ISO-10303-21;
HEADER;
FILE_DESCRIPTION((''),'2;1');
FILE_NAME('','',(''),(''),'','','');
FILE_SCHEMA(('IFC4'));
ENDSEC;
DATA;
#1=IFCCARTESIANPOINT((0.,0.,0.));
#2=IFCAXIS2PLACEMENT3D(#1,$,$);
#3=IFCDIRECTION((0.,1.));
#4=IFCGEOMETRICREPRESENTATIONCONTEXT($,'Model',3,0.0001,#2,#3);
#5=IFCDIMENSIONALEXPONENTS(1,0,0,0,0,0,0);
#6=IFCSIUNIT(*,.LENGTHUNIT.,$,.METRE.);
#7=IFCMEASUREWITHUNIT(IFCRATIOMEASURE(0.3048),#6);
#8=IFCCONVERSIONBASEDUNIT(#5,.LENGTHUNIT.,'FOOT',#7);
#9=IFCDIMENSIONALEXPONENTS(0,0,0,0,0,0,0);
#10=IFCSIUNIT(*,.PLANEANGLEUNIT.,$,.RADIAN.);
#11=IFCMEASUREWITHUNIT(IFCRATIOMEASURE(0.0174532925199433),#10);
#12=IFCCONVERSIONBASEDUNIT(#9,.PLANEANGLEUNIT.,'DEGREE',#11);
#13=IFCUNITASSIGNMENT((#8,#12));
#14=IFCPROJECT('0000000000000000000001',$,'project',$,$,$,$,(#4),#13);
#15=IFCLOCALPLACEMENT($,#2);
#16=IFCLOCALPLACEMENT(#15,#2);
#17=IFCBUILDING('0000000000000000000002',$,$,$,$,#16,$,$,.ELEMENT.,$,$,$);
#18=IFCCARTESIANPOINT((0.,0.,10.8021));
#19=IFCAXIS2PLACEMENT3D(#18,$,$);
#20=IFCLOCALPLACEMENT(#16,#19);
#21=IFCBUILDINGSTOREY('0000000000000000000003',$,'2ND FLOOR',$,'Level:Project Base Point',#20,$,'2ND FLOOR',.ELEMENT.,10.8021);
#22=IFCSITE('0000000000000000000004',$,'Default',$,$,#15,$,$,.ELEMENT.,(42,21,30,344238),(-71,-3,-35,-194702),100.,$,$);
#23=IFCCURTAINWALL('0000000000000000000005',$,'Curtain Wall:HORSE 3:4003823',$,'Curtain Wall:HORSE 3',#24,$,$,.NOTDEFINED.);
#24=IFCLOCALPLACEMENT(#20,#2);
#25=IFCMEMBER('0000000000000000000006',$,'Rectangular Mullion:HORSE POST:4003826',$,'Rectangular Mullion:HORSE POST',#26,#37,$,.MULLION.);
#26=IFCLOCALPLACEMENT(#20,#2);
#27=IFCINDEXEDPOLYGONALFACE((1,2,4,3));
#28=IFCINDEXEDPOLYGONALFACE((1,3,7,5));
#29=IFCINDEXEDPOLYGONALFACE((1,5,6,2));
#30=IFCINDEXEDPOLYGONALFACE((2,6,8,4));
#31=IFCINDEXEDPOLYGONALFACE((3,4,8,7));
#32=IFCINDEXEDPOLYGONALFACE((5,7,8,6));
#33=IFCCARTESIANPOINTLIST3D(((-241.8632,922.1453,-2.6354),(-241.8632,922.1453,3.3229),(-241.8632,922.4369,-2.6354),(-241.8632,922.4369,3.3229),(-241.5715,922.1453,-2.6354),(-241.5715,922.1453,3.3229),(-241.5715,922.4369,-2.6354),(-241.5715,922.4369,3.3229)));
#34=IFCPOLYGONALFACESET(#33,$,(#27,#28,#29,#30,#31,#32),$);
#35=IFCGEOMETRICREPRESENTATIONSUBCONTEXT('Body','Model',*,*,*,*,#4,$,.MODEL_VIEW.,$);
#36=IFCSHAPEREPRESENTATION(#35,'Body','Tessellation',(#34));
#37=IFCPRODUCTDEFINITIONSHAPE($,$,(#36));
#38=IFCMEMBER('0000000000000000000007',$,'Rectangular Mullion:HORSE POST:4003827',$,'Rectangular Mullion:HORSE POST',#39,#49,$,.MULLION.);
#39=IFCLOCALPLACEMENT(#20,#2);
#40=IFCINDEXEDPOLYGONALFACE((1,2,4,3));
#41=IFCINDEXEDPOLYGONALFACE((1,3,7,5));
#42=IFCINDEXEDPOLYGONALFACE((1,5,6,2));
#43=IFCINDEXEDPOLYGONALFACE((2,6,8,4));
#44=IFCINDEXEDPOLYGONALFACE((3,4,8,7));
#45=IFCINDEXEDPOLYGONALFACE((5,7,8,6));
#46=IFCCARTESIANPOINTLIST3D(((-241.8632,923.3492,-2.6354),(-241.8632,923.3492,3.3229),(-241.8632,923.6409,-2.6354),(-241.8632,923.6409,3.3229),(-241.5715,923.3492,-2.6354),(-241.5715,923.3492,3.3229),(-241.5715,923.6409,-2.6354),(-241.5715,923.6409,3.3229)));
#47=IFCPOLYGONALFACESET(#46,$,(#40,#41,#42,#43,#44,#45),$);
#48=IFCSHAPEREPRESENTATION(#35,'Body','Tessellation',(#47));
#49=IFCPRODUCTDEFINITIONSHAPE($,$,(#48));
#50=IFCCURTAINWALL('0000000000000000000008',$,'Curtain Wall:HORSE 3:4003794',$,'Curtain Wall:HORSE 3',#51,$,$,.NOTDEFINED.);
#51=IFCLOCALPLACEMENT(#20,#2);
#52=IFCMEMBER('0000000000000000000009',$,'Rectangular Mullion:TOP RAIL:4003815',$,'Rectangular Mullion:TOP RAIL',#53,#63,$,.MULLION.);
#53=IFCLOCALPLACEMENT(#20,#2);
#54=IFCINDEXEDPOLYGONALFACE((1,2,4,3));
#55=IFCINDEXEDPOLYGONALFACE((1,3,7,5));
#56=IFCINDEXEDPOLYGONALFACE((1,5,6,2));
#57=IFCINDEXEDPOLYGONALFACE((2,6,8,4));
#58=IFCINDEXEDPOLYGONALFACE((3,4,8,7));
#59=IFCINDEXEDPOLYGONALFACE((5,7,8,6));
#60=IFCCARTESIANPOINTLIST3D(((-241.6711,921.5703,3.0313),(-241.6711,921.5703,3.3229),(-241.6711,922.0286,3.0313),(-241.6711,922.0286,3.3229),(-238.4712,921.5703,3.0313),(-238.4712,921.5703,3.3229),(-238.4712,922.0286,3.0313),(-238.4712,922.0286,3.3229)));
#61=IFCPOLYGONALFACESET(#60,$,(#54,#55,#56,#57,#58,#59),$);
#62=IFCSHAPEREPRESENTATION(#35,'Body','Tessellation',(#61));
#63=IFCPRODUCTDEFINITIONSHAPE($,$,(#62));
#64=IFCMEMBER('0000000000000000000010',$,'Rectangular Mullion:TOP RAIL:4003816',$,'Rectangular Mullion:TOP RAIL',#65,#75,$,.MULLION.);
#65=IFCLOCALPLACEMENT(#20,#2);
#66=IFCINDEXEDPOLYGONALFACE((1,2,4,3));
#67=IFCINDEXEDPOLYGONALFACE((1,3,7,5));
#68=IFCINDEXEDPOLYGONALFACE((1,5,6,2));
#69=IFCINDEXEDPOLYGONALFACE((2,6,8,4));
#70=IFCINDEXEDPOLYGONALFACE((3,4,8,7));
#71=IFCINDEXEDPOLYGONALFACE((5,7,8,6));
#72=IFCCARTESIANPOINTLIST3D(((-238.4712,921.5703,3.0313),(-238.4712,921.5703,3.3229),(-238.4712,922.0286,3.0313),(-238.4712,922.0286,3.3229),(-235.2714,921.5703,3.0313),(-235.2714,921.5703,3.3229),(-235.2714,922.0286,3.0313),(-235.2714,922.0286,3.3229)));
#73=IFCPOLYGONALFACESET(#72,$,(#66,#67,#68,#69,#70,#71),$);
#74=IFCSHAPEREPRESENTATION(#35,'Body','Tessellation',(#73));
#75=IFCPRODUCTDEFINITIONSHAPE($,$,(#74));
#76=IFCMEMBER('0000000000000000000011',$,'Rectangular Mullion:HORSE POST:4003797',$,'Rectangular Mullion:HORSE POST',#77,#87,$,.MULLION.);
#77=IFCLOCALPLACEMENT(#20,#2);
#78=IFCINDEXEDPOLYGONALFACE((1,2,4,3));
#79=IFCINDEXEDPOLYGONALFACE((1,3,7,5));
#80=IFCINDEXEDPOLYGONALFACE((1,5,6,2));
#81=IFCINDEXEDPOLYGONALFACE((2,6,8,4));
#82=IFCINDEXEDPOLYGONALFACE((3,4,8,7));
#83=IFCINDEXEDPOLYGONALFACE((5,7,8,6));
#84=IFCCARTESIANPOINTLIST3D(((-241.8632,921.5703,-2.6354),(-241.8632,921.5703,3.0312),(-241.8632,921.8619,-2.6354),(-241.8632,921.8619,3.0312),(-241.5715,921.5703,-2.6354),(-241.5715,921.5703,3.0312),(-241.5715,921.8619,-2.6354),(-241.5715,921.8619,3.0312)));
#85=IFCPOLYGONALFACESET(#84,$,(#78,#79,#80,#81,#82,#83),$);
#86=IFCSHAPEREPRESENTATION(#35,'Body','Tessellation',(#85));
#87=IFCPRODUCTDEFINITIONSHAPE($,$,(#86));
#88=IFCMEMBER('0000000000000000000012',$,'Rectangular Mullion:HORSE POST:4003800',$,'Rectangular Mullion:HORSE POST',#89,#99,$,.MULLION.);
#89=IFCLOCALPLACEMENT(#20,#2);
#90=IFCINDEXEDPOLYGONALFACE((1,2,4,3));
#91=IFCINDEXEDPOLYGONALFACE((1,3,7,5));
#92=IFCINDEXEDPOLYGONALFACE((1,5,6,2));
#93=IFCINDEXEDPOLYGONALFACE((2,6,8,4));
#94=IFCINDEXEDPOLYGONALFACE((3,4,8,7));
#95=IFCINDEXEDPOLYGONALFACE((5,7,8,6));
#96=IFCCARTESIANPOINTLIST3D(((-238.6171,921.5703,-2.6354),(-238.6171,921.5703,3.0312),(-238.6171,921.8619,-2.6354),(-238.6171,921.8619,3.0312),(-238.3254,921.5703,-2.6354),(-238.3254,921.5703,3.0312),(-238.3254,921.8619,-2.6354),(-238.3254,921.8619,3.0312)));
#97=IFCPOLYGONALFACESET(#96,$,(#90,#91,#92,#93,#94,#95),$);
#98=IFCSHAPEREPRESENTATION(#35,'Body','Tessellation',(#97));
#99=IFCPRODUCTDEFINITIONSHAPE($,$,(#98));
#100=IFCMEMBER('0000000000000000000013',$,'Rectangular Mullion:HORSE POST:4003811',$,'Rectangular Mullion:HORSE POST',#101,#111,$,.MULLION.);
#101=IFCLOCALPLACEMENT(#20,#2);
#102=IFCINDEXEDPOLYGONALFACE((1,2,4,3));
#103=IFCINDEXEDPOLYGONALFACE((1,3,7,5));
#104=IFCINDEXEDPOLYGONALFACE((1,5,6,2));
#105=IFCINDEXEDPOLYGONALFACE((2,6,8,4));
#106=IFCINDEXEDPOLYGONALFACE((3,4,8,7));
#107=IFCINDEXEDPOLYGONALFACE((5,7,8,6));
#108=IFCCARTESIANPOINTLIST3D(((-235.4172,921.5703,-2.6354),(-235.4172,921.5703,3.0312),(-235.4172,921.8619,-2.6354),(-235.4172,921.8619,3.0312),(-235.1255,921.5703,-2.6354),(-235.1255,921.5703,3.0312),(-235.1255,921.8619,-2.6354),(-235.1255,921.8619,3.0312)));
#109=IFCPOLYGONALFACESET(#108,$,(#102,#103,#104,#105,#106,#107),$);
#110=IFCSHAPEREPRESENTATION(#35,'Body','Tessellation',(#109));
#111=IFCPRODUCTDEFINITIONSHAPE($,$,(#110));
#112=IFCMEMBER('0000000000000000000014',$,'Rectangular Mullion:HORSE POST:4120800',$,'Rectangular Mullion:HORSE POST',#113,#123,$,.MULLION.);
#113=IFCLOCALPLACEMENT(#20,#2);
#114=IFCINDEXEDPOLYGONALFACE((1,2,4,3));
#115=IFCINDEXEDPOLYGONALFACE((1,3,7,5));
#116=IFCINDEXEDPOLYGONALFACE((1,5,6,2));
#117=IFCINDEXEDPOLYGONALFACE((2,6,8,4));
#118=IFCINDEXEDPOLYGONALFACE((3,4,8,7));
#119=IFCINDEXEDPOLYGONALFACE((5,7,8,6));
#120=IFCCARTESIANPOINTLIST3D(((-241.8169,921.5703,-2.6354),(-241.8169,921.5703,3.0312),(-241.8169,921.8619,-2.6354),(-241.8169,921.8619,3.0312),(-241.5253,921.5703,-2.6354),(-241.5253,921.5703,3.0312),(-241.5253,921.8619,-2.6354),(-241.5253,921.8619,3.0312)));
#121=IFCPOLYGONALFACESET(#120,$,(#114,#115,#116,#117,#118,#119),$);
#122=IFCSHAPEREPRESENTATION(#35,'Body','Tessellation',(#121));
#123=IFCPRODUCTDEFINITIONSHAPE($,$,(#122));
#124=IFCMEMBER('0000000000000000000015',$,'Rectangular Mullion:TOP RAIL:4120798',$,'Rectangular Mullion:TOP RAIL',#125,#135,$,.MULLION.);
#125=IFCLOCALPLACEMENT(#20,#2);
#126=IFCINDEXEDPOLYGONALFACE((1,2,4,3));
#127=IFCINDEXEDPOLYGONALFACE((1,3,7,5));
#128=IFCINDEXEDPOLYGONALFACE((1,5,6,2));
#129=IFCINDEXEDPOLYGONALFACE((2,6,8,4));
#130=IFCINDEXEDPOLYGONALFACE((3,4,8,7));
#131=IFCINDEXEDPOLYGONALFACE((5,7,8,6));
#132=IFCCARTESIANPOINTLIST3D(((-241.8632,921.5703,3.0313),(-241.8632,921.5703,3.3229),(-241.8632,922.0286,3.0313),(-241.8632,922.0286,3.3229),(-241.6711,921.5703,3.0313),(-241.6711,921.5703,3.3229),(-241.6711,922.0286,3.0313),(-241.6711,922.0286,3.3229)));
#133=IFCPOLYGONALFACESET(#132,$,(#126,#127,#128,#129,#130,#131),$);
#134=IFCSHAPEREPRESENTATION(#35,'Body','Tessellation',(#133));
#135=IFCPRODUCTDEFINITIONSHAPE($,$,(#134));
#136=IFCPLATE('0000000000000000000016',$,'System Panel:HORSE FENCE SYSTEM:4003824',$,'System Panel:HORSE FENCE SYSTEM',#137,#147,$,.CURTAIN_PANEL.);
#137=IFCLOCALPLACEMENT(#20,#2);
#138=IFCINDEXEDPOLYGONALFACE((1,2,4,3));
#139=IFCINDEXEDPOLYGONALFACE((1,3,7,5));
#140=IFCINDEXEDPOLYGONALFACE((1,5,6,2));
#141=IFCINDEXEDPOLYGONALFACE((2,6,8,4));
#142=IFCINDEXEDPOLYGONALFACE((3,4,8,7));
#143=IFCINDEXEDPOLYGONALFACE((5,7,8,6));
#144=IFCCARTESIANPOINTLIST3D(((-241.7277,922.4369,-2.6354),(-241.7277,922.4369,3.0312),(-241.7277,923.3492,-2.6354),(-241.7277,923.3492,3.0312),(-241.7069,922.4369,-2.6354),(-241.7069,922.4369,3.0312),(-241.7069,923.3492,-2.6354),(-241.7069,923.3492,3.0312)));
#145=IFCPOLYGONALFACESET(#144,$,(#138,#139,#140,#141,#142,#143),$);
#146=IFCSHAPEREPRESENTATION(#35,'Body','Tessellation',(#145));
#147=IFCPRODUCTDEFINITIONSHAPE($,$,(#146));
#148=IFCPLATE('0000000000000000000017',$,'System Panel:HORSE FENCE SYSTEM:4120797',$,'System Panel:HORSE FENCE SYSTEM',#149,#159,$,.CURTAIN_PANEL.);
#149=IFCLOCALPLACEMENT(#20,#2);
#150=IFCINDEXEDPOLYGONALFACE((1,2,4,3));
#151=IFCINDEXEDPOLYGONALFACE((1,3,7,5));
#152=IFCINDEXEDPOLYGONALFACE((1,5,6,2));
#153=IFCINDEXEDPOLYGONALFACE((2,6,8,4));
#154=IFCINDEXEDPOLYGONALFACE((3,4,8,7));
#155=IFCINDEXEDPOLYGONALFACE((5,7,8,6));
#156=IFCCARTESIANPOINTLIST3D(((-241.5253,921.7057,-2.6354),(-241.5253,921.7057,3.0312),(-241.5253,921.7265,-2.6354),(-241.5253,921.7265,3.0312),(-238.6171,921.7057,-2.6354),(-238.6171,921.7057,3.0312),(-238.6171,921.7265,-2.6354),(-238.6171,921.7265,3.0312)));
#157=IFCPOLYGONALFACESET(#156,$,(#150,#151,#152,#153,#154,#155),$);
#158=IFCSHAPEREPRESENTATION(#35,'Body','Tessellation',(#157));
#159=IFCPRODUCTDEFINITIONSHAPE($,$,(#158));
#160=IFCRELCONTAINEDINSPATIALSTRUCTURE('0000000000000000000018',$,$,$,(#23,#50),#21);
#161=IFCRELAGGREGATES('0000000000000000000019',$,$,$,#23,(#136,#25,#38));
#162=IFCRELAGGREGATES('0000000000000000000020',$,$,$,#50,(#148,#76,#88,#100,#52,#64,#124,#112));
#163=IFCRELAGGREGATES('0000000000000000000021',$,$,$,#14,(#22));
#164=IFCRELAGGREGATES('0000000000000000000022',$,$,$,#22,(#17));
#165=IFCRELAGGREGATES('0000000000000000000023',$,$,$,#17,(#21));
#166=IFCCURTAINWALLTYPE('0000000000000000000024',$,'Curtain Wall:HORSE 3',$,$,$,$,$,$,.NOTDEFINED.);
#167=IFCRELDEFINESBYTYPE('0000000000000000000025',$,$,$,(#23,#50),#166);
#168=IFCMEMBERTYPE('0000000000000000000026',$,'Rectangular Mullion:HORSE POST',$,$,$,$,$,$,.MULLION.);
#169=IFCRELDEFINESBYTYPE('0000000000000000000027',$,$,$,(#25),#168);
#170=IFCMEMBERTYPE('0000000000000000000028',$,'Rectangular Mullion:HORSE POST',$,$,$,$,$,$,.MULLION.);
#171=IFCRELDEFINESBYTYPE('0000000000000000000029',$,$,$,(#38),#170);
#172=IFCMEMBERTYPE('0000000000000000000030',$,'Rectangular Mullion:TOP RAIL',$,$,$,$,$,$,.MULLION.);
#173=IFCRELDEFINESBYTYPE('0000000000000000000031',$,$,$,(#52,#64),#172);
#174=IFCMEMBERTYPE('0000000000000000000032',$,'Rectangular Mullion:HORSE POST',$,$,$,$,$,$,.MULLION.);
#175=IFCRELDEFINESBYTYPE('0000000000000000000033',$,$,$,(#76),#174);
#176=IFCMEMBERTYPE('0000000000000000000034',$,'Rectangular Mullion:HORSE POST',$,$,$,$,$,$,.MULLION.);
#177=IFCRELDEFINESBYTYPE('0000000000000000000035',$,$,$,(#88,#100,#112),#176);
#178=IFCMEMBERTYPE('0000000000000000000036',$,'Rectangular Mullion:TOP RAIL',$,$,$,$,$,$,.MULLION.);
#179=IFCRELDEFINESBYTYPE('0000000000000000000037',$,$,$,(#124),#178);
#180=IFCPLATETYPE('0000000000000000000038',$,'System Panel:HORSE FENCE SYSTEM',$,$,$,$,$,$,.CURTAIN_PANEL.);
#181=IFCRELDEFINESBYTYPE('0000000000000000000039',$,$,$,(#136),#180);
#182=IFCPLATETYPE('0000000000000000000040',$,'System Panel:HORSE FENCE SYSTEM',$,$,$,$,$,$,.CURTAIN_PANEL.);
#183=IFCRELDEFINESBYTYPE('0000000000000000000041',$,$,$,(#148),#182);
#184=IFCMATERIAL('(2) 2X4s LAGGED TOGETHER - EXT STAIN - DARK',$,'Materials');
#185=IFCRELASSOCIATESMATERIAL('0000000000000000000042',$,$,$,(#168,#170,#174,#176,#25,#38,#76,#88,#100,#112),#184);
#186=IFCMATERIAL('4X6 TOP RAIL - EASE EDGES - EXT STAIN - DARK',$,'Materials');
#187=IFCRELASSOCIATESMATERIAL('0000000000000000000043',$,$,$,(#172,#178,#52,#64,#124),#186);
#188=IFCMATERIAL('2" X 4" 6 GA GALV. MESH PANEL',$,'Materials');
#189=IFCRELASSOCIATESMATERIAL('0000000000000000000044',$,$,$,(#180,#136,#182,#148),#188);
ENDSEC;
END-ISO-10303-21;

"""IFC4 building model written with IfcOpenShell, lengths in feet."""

from ifc_helpers import new_model, entity, si_unit, converted_unit, direction, frame, frame_2d, origin, origin_2d_with_axis, place, context, subcontext, project, spatial, rectangle, extrude, source, transform, mapped, material, material_profile, profile_set, profile_usage, type_object, type_shapes, element, aggregate, save


model = new_model("IFC4")

# Units and contexts
model_context = context("Model", 3, precision=0.0001, world=origin(), true_north=direction((0.0, 1.0)))
body_context = subcontext(model_context, "Body", "Model", "MODEL_VIEW")
ifc_project = project(units=[converted_unit("LENGTHUNIT", "FOOT", entity("IfcRatioMeasure", 0.3048), si_unit("LENGTHUNIT", "METRE"), dimensions=[1, 0, 0, 0, 0, 0, 0]), converted_unit("PLANEANGLEUNIT", "DEGREE", entity("IfcRatioMeasure", 0.0174532925199433), si_unit("PLANEANGLEUNIT", "RADIAN"), dimensions=[0, 0, 0, 0, 0, 0, 0])], contexts=[model_context])

# Site, building, storey
site_placement = place(None, origin())
site = spatial("IfcSite", under=ifc_project, at=site_placement, Name="Default", CompositionType="ELEMENT", RefLatitude=(42, 21, 30, 344238), RefLongitude=(-71, -3, -35, -194702), RefElevation=100.0)
building_placement = place(site_placement, origin())
building = spatial("IfcBuilding", under=site, at=building_placement, CompositionType="ELEMENT")
storey_placement = place(building_placement, frame((0.0, 0.0, 10.8021)))
storey = spatial("IfcBuildingStorey", under=building, at=storey_placement, Name="2ND FLOOR", ObjectType="Level:Project Base Point", LongName="2ND FLOOR", CompositionType="ELEMENT", Elevation=10.8021)

# Curtain walls, members
curtain_wall_type = type_object("IfcCurtainWallType", Name="Curtain Wall:HORSE 3", PredefinedType="NOTDEFINED")
curtain_wall_1_placement = place(storey_placement, frame((0.0, 0.0, -10.8021)))
curtain_wall_1 = element("IfcCurtainWall", 1, at=curtain_wall_1_placement, inside=storey, type_object=curtain_wall_type, Name="Curtain Wall:HORSE 3:4003823", ObjectType="Curtain Wall:HORSE 3", PredefinedType="NOTDEFINED")
ifc_material_1 = material(Name="4X6 TOP RAIL - EASE EDGES - EXT STAIN - DARK", Category="Materials")
ifc_material_profile_1 = material_profile(ifc_material_1, rectangle(XDim=0.4583, YDim=0.2917, at=origin_2d_with_axis()), Name="TOP RAIL")
ifc_profile_set_1 = profile_set([ifc_material_profile_1], Name="TOP RAIL")
placement = place(building_placement, frame((0.0, 0.0, 21.4688)))
ifc_material_2 = material(Name="(2) 2X4s LAGGED TOGETHER - EXT STAIN - DARK", Category="Materials")
ifc_material_profile_2 = material_profile(ifc_material_2, rectangle(XDim=0.2917, YDim=0.2917, at=frame_2d((0.0, 0.0), x_axis=(1.0, 0.0))), Name="HORSE POST")
ifc_profile_set_2 = profile_set([ifc_material_profile_2], Name="HORSE POST")
ifc_profile_usage_1 = profile_usage(ifc_profile_set_2)
member_type_1 = type_object("IfcMemberType", Name="Rectangular Mullion:HORSE POST", PredefinedType="MULLION", material=ifc_profile_set_2)
shared_shape_1 = source(origin(), body_context, "Body", "SweptSolid", [
    extrude(rectangle(XDim=0.2917, YDim=0.2917, at=origin_2d_with_axis()), frame((-0.1458, 0.1458, -5.9583), z_axis=(0.0, 0.0, 1.0), x_axis=(0.0, -1.0, 0.0)), (0.0, 0.0, 1.0), 5.9583),
])
type_shapes(member_type_1, [shared_shape_1])
member_1_placement = place(placement, frame((-241.5715, 922.1453, -13.3021), z_axis=(0.0, 0.0, -1.0), x_axis=(0.0, -1.0, 0.0)))
member_1 = element("IfcMember", 2, at=member_1_placement, type_object=member_type_1, material=ifc_profile_usage_1, Name="Rectangular Mullion:HORSE POST:4003826", ObjectType="Rectangular Mullion:HORSE POST", PredefinedType="MULLION", context=body_context, shape_type="MappedRepresentation", body=[
    mapped(shared_shape_1, transform((0.0, 0.0, 0.0), scale=1.0)),
])
ifc_profile_usage_2 = profile_usage(ifc_profile_set_2)
member_type_2 = type_object("IfcMemberType", Name="Rectangular Mullion:HORSE POST", PredefinedType="MULLION", material=ifc_profile_set_2)
shared_shape_2 = source(origin(), body_context, "Body", "SweptSolid", [
    extrude(rectangle(XDim=0.2917, YDim=0.2917, at=origin_2d_with_axis()), frame((-0.1458, 0.1458, -5.9583), z_axis=(0.0, 0.0, 1.0), x_axis=(0.0, -1.0, 0.0)), (0.0, 0.0, 1.0), 5.9583),
])
type_shapes(member_type_2, [shared_shape_2])
member_2_placement = place(placement, frame((-241.5715, 923.6409, -7.3438), z_axis=(0.0, 0.0, 1.0), x_axis=(0.0, 1.0, 0.0)))
member_2 = element("IfcMember", 3, at=member_2_placement, type_object=member_type_2, material=ifc_profile_usage_2, Name="Rectangular Mullion:HORSE POST:4003827", ObjectType="Rectangular Mullion:HORSE POST", PredefinedType="MULLION", context=body_context, shape_type="MappedRepresentation", body=[
    mapped(shared_shape_2, transform((0.0, 0.0, 0.0), scale=1.0)),
])
curtain_wall_2_placement = place(storey_placement, frame((0.0, 0.0, -10.8021)))
curtain_wall_2 = element("IfcCurtainWall", 4, at=curtain_wall_2_placement, inside=storey, type_object=curtain_wall_type, Name="Curtain Wall:HORSE 3:4003794", ObjectType="Curtain Wall:HORSE 3", PredefinedType="NOTDEFINED")
ifc_profile_usage_3 = profile_usage(ifc_profile_set_1)
member_type_3 = type_object("IfcMemberType", Name="Rectangular Mullion:TOP RAIL", PredefinedType="MULLION", material=ifc_profile_set_1)
shared_shape_3 = source(origin(), body_context, "Body", "SweptSolid", [
    extrude(rectangle(XDim=0.4583, YDim=0.2917, at=origin_2d_with_axis()), frame((-0.1458, 0.0625, -3.1999), z_axis=(0.0, 0.0, 1.0), x_axis=(0.0, -1.0, 0.0)), (0.0, 0.0, 1.0), 3.1999),
])
type_shapes(member_type_3, [shared_shape_3])
member_3_placement = place(storey_placement, frame((-238.4712, 921.8619, 3.3229), z_axis=(1.0, 0.0, 0.0), x_axis=(0.0, 0.0, 1.0)))
member_3 = element("IfcMember", 5, at=member_3_placement, type_object=member_type_3, material=ifc_profile_usage_3, Name="Rectangular Mullion:TOP RAIL:4003815", ObjectType="Rectangular Mullion:TOP RAIL", PredefinedType="MULLION", context=body_context, shape_type="MappedRepresentation", body=[
    mapped(shared_shape_3, transform((0.0, 0.0, 0.0), scale=1.0)),
])
ifc_profile_usage_4 = profile_usage(ifc_profile_set_1)
member_4_placement = place(storey_placement, frame((-235.2714, 921.8619, 3.3229), z_axis=(1.0, 0.0, 0.0), x_axis=(0.0, 0.0, 1.0)))
member_4 = element("IfcMember", 6, at=member_4_placement, type_object=member_type_3, material=ifc_profile_usage_4, Name="Rectangular Mullion:TOP RAIL:4003816", ObjectType="Rectangular Mullion:TOP RAIL", PredefinedType="MULLION", context=body_context, shape_type="MappedRepresentation", body=[
    mapped(shared_shape_3, transform((0.0, 0.0, 0.0), scale=1.0)),
])
ifc_profile_usage_5 = profile_usage(ifc_profile_set_2)
member_type_4 = type_object("IfcMemberType", Name="Rectangular Mullion:HORSE POST", PredefinedType="MULLION", material=ifc_profile_set_2)
shared_shape_4 = source(origin(), body_context, "Body", "SweptSolid", [
    extrude(rectangle(XDim=0.2917, YDim=0.2917, at=origin_2d_with_axis()), frame((-0.1458, 0.1458, -5.6667), z_axis=(0.0, 0.0, 1.0), x_axis=(0.0, -1.0, 0.0)), (0.0, 0.0, 1.0), 5.6667),
])
type_shapes(member_type_4, [shared_shape_4])
member_5_placement = place(placement, frame((-241.8632, 921.8619, -7.6354), z_axis=(0.0, 0.0, 1.0), x_axis=(-1.0, 0.0, 0.0)))
member_5 = element("IfcMember", 7, at=member_5_placement, type_object=member_type_4, material=ifc_profile_usage_5, Name="Rectangular Mullion:HORSE POST:4003797", ObjectType="Rectangular Mullion:HORSE POST", PredefinedType="MULLION", context=body_context, shape_type="MappedRepresentation", body=[
    mapped(shared_shape_4, transform((0.0, 0.0, 0.0), scale=1.0)),
])
ifc_profile_usage_6 = profile_usage(ifc_profile_set_2)
member_type_5 = type_object("IfcMemberType", Name="Rectangular Mullion:HORSE POST", PredefinedType="MULLION", material=ifc_profile_set_2)
shared_shape_5 = source(origin(), body_context, "Body", "SweptSolid", [
    extrude(rectangle(XDim=0.2917, YDim=0.2917, at=origin_2d_with_axis()), frame((0.0, 0.1458, -5.6667), z_axis=(0.0, 0.0, 1.0), x_axis=(0.0, -1.0, 0.0)), (0.0, 0.0, 1.0), 5.6667),
])
type_shapes(member_type_5, [shared_shape_5])
member_6_placement = place(placement, frame((-238.4712, 921.8619, -13.3021), z_axis=(0.0, 0.0, -1.0), x_axis=(1.0, 0.0, 0.0)))
member_6 = element("IfcMember", 8, at=member_6_placement, type_object=member_type_5, material=ifc_profile_usage_6, Name="Rectangular Mullion:HORSE POST:4003800", ObjectType="Rectangular Mullion:HORSE POST", PredefinedType="MULLION", context=body_context, shape_type="MappedRepresentation", body=[
    mapped(shared_shape_5, transform((0.0, 0.0, 0.0), scale=1.0)),
])
ifc_profile_usage_7 = profile_usage(ifc_profile_set_2)
member_7_placement = place(storey_placement, frame((-235.2714, 921.8619, -2.6354), z_axis=(0.0, 0.0, -1.0), x_axis=(1.0, 0.0, 0.0)))
member_7 = element("IfcMember", 9, at=member_7_placement, type_object=member_type_5, material=ifc_profile_usage_7, Name="Rectangular Mullion:HORSE POST:4003811", ObjectType="Rectangular Mullion:HORSE POST", PredefinedType="MULLION", context=body_context, shape_type="MappedRepresentation", body=[
    mapped(shared_shape_5, transform((0.0, 0.0, 0.0), scale=1.0)),
])
ifc_profile_usage_8 = profile_usage(ifc_profile_set_2)
member_8_placement = place(storey_placement, frame((-241.6711, 921.8619, -2.6354), z_axis=(0.0, 0.0, -1.0), x_axis=(1.0, 0.0, 0.0)))
member_8 = element("IfcMember", 10, at=member_8_placement, type_object=member_type_5, material=ifc_profile_usage_8, Name="Rectangular Mullion:HORSE POST:4120800", ObjectType="Rectangular Mullion:HORSE POST", PredefinedType="MULLION", context=body_context, shape_type="MappedRepresentation", body=[
    mapped(shared_shape_5, transform((0.0, 0.0, 0.0), scale=1.0)),
])
ifc_profile_usage_9 = profile_usage(ifc_profile_set_1)
member_type_6 = type_object("IfcMemberType", Name="Rectangular Mullion:TOP RAIL", PredefinedType="MULLION", material=ifc_profile_set_1)
shared_shape_6 = source(origin(), body_context, "Body", "SweptSolid", [
    extrude(rectangle(XDim=0.4583, YDim=0.2917, at=origin_2d_with_axis()), frame((-0.1458, 0.0625, -0.1921), z_axis=(0.0, 0.0, 1.0), x_axis=(0.0, -1.0, 0.0)), (0.0, 0.0, 1.0), 0.1921),
])
type_shapes(member_type_6, [shared_shape_6])
member_9_placement = place(storey_placement, frame((-241.6711, 921.8619, 3.3229), z_axis=(1.0, 0.0, 0.0), x_axis=(0.0, 0.0, 1.0)))
member_9 = element("IfcMember", 11, at=member_9_placement, type_object=member_type_6, material=ifc_profile_usage_9, Name="Rectangular Mullion:TOP RAIL:4120798", ObjectType="Rectangular Mullion:TOP RAIL", PredefinedType="MULLION", context=body_context, shape_type="MappedRepresentation", body=[
    mapped(shared_shape_6, transform((0.0, 0.0, 0.0), scale=1.0)),
])

# Plates
ifc_material_3 = material(Name="2\" X 4\" 6 GA GALV. MESH PANEL", Category="Materials")
plate_type_1 = type_object("IfcPlateType", Name="System Panel:HORSE FENCE SYSTEM", PredefinedType="CURTAIN_PANEL", material=ifc_material_3)
shared_shape_7 = source(origin(), body_context, "Body", "SweptSolid", [
    extrude(rectangle(XDim=0.0208, YDim=0.9123, at=frame_2d((0.0, 0.0), x_axis=(1.0, 0.0))), frame((0.4561, 0.0104, 0.0), z_axis=(0.0, 0.0, 1.0), x_axis=(0.0, 1.0, 0.0)), (0.0, 0.0, 1.0), 5.6667),
])
type_shapes(plate_type_1, [shared_shape_7])
plate_1_placement = place(curtain_wall_1_placement, frame((-241.7277, 923.3492, 8.1667), z_axis=(0.0, 0.0, 1.0), x_axis=(0.0, -1.0, 0.0)))
plate_1 = element("IfcPlate", 12, at=plate_1_placement, type_object=plate_type_1, material=ifc_material_3, Name="System Panel:HORSE FENCE SYSTEM:4003824", ObjectType="System Panel:HORSE FENCE SYSTEM", PredefinedType="CURTAIN_PANEL", context=body_context, shape_type="MappedRepresentation", body=[
    mapped(shared_shape_7, transform((0.0, 0.0, 0.0), scale=1.0)),
])
aggregate(curtain_wall_1, [plate_1, member_1, member_2])
plate_type_2 = type_object("IfcPlateType", Name="System Panel:HORSE FENCE SYSTEM", PredefinedType="CURTAIN_PANEL", material=ifc_material_3)
shared_shape_8 = source(origin(), body_context, "Body", "SweptSolid", [
    extrude(rectangle(XDim=0.0208, YDim=2.9082, at=frame_2d((0.0, 0.0), x_axis=(1.0, 0.0))), frame((1.4541, 0.0104, 0.0), z_axis=(0.0, 0.0, 1.0), x_axis=(0.0, 1.0, 0.0)), (0.0, 0.0, 1.0), 5.6667),
])
type_shapes(plate_type_2, [shared_shape_8])
plate_2_placement = place(curtain_wall_2_placement, frame((-241.5253, 921.7057, 8.1667)))
plate_2 = element("IfcPlate", 13, at=plate_2_placement, type_object=plate_type_2, material=ifc_material_3, Name="System Panel:HORSE FENCE SYSTEM:4120797", ObjectType="System Panel:HORSE FENCE SYSTEM", PredefinedType="CURTAIN_PANEL", context=body_context, shape_type="MappedRepresentation", body=[
    mapped(shared_shape_8, transform((0.0, 0.0, 0.0), scale=1.0)),
])
aggregate(curtain_wall_2, [plate_2, member_5, member_6, member_7, member_3, member_4, member_9, member_8])

save(model, "model.ifc")
